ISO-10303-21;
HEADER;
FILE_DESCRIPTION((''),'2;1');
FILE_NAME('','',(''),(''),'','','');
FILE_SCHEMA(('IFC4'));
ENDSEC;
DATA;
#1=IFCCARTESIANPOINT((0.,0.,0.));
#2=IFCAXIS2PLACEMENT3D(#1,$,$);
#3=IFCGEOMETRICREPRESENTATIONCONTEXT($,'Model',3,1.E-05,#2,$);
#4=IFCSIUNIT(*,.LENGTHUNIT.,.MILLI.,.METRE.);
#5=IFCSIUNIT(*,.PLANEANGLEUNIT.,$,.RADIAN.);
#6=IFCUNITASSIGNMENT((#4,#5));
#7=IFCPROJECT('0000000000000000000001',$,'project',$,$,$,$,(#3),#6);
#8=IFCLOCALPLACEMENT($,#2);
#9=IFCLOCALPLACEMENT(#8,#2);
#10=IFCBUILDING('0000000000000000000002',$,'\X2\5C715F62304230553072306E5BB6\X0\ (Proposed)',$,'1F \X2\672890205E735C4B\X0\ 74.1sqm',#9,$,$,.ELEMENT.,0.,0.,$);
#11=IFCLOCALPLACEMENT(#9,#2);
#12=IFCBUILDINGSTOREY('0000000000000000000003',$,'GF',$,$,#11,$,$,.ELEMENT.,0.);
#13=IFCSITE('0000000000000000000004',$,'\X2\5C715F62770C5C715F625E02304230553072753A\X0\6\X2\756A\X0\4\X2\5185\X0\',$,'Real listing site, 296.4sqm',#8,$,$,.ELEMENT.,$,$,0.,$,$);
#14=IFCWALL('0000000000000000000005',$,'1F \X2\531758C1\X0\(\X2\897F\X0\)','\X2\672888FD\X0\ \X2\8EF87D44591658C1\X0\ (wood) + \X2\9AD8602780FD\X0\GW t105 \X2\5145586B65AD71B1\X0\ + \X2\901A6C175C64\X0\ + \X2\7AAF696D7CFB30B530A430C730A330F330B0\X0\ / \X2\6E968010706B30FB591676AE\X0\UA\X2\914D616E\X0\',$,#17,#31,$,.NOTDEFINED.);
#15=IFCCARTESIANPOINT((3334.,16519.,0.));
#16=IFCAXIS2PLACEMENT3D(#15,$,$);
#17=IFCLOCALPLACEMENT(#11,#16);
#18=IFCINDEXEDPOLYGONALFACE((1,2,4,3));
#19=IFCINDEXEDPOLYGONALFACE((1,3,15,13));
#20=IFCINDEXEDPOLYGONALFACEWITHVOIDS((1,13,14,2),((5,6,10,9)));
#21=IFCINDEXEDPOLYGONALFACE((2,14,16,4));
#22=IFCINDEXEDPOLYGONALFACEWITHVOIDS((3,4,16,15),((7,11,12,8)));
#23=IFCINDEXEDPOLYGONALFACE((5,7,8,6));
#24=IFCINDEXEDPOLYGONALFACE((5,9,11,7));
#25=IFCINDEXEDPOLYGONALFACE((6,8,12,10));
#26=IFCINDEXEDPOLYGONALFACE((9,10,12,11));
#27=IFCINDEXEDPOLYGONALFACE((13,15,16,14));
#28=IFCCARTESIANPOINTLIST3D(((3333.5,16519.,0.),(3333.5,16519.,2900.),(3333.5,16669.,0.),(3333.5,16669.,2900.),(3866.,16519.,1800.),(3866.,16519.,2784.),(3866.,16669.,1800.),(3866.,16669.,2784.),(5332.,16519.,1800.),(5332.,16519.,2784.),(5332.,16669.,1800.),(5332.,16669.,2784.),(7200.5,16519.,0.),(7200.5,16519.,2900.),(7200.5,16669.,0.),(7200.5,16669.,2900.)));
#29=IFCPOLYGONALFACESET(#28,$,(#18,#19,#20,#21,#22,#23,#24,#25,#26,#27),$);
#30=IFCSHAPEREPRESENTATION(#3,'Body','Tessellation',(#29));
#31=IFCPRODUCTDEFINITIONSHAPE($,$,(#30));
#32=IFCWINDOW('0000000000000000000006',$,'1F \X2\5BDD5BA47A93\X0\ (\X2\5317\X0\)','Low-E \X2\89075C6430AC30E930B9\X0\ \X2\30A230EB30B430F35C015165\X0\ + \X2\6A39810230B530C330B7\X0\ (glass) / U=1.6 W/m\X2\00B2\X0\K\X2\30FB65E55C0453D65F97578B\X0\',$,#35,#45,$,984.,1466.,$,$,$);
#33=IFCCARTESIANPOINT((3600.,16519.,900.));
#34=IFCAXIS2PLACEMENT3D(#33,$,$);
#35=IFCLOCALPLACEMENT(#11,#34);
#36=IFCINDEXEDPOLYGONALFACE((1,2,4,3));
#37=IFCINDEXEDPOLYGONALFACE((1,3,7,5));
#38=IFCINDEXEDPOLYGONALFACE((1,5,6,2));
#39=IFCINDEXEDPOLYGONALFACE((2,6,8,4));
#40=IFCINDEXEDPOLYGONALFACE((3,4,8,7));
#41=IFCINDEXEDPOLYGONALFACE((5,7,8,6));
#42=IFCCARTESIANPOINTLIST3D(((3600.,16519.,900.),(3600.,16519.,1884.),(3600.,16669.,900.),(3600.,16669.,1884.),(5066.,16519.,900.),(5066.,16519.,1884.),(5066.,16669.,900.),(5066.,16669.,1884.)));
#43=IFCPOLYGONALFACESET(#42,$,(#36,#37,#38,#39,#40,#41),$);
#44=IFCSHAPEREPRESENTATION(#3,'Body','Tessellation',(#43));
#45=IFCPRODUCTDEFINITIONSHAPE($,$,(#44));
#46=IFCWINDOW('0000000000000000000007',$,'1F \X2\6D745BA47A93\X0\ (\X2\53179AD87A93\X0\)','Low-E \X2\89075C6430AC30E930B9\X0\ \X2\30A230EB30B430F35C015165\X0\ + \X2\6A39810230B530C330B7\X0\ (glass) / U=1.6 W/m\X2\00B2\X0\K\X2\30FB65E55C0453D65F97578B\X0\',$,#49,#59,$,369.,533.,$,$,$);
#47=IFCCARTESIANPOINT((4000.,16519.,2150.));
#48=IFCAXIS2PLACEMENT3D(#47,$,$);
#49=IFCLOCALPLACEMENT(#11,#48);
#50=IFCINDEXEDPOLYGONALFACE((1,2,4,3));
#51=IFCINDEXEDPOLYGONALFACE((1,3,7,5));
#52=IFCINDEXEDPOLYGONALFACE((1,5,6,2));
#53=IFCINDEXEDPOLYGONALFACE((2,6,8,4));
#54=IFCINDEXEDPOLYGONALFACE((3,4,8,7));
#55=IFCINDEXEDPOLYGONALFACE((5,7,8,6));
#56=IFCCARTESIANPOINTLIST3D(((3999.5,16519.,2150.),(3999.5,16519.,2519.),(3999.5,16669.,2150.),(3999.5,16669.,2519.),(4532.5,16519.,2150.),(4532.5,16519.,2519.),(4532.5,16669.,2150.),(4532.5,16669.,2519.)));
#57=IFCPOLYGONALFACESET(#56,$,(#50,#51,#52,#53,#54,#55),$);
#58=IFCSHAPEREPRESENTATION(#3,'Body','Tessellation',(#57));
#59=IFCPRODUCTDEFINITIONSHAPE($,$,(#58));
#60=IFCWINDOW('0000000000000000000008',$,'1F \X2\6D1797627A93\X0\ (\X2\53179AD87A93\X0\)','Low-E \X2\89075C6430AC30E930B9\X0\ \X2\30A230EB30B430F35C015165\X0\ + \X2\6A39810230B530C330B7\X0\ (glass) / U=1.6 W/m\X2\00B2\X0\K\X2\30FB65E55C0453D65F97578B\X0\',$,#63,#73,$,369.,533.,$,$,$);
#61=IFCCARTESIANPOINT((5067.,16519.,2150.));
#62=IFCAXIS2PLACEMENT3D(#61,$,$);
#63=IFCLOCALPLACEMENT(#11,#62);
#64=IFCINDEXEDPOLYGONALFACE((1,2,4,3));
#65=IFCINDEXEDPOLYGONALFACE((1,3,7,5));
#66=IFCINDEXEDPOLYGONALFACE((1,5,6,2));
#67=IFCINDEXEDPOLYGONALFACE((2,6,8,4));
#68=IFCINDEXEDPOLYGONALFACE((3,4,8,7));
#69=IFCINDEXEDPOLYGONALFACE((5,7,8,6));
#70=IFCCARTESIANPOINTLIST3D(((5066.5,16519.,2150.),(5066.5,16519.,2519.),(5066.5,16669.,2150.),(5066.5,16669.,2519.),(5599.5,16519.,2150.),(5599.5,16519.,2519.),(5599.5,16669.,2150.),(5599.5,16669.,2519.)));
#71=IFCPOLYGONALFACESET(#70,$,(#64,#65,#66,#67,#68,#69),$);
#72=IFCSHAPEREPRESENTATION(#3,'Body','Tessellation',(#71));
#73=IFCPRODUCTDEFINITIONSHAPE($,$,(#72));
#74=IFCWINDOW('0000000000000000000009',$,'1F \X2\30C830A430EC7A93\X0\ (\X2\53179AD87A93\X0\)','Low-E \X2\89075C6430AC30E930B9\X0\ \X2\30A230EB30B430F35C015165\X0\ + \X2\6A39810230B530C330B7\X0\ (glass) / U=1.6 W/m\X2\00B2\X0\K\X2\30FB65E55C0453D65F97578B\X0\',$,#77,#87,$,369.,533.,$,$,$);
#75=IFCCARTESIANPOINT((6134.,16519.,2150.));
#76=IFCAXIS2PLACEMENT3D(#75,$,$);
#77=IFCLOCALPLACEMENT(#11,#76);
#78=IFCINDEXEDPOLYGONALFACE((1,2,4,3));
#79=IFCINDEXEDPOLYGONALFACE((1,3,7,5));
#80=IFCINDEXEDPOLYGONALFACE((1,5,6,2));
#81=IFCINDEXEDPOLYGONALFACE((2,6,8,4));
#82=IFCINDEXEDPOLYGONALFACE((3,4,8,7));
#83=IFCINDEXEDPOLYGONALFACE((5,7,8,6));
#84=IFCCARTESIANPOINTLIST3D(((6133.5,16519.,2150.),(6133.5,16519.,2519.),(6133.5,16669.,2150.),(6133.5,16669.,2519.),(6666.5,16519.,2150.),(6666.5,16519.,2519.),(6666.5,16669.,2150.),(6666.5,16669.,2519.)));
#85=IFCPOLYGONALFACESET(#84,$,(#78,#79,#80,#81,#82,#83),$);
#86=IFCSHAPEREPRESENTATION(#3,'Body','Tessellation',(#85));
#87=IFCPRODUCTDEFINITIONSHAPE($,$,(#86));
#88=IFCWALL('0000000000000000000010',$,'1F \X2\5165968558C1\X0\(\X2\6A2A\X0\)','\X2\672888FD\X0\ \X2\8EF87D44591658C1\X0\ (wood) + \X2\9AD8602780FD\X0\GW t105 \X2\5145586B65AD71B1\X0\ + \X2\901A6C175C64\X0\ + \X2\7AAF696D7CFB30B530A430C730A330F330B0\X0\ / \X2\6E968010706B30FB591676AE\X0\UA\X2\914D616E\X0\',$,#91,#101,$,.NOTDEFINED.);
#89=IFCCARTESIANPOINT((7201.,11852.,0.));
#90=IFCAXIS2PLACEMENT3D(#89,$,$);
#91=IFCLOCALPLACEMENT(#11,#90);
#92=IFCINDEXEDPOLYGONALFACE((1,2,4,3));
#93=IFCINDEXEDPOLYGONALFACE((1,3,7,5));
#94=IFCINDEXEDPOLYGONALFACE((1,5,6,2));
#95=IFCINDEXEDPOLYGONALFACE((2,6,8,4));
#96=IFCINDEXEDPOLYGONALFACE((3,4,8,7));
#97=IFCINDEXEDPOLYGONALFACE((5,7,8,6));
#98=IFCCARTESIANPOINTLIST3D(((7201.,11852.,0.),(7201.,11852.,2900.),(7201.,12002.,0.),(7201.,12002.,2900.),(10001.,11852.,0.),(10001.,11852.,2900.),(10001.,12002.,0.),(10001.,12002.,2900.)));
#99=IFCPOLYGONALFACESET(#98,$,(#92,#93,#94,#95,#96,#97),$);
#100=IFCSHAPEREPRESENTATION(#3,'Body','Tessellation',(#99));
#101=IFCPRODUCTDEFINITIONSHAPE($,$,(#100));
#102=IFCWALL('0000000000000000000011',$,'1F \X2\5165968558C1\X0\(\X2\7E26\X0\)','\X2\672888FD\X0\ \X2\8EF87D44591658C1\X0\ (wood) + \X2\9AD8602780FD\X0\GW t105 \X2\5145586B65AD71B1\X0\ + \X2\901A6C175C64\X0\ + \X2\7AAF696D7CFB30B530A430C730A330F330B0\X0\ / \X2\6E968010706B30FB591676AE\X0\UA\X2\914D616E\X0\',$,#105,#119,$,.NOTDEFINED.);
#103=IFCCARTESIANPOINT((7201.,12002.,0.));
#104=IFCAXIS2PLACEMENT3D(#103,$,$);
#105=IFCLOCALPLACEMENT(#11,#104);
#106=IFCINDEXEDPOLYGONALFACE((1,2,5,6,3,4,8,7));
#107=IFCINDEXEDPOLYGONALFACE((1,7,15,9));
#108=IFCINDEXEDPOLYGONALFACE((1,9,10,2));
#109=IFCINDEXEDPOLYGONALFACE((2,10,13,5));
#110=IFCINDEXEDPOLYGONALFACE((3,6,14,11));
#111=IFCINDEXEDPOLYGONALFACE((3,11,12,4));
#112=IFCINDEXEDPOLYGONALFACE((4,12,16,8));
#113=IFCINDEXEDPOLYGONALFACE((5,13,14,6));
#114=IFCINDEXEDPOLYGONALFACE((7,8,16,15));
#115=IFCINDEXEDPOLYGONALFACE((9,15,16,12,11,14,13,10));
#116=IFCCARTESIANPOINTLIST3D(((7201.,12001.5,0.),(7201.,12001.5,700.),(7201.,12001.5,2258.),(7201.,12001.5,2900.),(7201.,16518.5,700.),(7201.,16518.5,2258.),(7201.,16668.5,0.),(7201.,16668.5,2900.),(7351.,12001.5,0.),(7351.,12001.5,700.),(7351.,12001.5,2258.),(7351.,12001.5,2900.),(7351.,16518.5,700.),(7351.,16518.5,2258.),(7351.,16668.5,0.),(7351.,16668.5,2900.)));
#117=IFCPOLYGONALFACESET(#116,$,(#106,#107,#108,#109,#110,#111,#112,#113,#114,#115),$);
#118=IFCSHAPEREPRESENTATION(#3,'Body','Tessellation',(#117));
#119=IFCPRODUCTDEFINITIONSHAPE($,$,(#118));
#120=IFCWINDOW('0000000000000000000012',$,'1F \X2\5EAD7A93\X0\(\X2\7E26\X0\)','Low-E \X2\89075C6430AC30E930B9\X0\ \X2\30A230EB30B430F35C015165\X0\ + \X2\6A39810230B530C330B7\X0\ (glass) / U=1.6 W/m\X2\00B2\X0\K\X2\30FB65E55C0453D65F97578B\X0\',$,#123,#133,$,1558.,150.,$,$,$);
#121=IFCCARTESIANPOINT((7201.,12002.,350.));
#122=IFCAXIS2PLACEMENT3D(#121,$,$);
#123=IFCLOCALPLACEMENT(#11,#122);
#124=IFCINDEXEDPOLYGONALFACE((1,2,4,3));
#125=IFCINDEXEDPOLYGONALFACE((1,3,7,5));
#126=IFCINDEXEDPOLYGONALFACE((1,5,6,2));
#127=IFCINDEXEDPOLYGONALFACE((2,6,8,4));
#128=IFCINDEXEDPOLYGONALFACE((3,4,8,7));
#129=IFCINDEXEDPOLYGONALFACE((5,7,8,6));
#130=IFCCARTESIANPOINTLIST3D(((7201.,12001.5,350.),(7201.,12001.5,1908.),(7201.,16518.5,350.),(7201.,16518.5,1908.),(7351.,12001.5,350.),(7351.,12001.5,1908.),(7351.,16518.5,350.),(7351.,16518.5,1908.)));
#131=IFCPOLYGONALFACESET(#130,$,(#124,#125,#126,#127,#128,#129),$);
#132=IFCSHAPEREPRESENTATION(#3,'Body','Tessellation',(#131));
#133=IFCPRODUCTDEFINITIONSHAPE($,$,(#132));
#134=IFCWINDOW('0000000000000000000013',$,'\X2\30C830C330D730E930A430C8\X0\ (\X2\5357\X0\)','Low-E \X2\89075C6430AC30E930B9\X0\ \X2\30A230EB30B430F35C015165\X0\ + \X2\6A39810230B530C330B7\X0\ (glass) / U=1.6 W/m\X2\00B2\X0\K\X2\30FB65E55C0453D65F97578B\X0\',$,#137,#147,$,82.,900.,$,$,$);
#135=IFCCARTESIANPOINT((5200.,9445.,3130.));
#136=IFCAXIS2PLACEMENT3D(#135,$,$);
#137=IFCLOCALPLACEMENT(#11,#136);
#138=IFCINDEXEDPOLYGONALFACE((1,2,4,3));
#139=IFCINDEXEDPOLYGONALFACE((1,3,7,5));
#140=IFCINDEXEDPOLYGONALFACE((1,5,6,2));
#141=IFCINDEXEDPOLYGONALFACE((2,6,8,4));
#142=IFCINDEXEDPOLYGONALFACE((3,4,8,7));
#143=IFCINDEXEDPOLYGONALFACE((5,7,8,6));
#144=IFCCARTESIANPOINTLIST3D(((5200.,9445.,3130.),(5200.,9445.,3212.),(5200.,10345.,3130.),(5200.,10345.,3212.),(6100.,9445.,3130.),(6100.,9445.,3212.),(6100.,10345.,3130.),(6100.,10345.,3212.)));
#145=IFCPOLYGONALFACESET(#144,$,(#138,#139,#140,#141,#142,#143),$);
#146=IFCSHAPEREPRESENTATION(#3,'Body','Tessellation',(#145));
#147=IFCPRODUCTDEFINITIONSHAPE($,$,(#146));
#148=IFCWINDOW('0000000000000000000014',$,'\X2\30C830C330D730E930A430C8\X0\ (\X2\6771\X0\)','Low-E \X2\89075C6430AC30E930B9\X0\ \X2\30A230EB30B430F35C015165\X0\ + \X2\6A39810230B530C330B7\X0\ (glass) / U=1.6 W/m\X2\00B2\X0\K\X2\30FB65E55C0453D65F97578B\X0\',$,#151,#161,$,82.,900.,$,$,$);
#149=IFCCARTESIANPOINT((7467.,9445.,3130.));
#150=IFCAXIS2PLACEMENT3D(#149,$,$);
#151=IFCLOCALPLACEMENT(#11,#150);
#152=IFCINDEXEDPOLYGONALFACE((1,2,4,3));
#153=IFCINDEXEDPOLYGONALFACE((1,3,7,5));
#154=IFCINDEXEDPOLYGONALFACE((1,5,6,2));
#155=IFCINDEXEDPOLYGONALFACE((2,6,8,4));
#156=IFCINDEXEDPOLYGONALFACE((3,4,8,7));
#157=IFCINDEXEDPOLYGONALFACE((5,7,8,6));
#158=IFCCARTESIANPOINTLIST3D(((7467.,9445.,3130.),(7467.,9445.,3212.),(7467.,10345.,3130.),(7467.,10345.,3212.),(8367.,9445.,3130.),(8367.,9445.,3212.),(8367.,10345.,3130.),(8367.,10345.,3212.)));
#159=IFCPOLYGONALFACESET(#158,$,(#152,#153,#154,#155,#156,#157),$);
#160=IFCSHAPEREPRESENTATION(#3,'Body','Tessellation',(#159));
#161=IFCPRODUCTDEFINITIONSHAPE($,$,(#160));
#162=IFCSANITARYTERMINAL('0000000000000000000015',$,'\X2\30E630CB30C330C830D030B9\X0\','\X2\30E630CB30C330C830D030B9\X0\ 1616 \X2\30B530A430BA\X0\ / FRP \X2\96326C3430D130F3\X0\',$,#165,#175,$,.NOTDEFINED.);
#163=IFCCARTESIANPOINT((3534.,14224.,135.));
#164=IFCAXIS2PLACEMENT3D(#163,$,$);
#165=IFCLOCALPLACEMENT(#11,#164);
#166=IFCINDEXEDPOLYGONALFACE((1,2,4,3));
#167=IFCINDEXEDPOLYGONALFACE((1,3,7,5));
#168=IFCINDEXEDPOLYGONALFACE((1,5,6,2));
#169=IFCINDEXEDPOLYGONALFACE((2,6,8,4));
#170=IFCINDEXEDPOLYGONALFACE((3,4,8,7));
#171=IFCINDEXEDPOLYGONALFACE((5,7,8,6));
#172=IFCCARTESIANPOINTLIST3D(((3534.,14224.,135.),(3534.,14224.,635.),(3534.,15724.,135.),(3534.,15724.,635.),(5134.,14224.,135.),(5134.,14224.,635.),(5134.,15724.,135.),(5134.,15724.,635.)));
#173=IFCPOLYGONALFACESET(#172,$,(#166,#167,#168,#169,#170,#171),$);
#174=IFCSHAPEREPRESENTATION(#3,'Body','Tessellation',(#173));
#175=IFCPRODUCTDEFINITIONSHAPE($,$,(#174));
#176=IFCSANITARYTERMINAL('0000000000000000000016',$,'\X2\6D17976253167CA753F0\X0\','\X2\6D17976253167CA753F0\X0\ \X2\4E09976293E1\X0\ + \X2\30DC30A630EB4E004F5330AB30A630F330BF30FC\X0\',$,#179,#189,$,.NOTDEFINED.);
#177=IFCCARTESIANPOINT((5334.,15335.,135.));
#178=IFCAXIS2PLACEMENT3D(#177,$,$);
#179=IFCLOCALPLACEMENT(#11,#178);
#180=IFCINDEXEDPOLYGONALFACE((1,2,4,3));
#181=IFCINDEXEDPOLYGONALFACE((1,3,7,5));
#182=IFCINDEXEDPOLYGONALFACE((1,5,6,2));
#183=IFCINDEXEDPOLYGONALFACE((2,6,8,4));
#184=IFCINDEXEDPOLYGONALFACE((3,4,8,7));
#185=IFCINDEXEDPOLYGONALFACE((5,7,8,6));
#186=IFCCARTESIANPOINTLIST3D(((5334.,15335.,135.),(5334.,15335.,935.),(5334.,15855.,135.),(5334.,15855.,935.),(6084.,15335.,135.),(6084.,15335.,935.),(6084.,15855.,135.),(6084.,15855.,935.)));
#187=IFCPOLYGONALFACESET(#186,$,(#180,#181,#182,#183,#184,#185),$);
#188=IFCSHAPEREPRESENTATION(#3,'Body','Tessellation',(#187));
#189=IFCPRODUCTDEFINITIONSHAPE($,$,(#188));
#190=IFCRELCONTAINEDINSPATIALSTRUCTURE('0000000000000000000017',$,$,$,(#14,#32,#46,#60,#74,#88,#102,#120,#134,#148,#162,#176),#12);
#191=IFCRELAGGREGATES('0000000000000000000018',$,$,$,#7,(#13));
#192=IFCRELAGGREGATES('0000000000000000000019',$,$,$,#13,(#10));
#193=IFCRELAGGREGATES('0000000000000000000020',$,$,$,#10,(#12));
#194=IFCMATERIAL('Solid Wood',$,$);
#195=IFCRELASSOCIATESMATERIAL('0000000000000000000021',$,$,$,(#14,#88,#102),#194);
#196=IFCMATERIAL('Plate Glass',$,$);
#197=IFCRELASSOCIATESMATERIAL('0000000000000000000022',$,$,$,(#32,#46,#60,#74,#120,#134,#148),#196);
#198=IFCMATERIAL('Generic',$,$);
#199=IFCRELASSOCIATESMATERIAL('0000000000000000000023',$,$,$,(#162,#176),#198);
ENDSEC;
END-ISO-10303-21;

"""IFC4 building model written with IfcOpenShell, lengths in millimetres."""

from ifc_helpers import new_model, si_unit, frame, frame_2d, origin, place, context, project, spatial, rectangle, extrude, material, element, fill, save


model = new_model("IFC4")

# Units and contexts
model_context = context("Model", 3, precision=1e-05, world=origin())
ifc_project = project(units=[si_unit("LENGTHUNIT", "METRE", prefix="MILLI"), si_unit("PLANEANGLEUNIT", "RADIAN")], contexts=[model_context])

# Site, building, storey
site_placement = place(None, origin())
site = spatial("IfcSite", under=ifc_project, at=site_placement, Name="山形県山形市あさひ町6番4内", ObjectType="Real listing site, 296.4sqm", CompositionType="ELEMENT", RefElevation=0.0)
building_placement = place(site_placement, origin())
building = spatial("IfcBuilding", under=site, at=building_placement, Name="山形あさひの家 (Proposed)", ObjectType="1F 木造平屋 74.1sqm", CompositionType="ELEMENT", ElevationOfRefHeight=0.0, ElevationOfTerrain=0.0)
storey_placement = place(building_placement, origin())
storey = spatial("IfcBuildingStorey", under=building, at=storey_placement, Name="GF", CompositionType="ELEMENT", Elevation=0.0)

# Shared definitions
ifc_material_1 = material(Name="Solid Wood")

# Wall, openings, windows
wall_1_placement = place(storey_placement, frame((3334.0, 16519.0, 0.0)))
wall_1 = element("IfcWall", 1, at=wall_1_placement, inside=storey, material=ifc_material_1, Name="1F 北壁(西)", Description="木製 軸組外壁 (wood) + 高性能GW t105 充填断熱 + 通気層 + 窯業系サイディング / 準耐火・外皮UA配慮", PredefinedType="NOTDEFINED", context=model_context, shape_type="SweptSolid", body=[
    extrude(rectangle(XDim=3867.0, YDim=150.0, at=frame_2d((1933.0, 75.0))), frame((3334.0, 16519.0, 0.0)), (0.0, 0.0, 1.0), 2900.0),
])
opening_1_placement = place(storey_placement, frame((3600.0, 16519.0, 900.0)))
opening_1 = element("IfcOpeningElement", 2, at=opening_1_placement, cuts=wall_1, PredefinedType="NOTDEFINED", context=model_context, shape_type="SweptSolid", body=[
    extrude(rectangle(XDim=1466.0, YDim=150.0, at=frame_2d((733.0, 75.0))), frame((3600.0, 16519.0, 900.0)), (0.0, 0.0, 1.0), 984.0),
])
opening_2_placement = place(storey_placement, frame((4000.0, 16519.0, 2150.0)))
opening_2 = element("IfcOpeningElement", 3, at=opening_2_placement, cuts=wall_1, PredefinedType="NOTDEFINED", context=model_context, shape_type="SweptSolid", body=[
    extrude(rectangle(XDim=533.0, YDim=150.0, at=frame_2d((266.0, 75.0))), frame((4000.0, 16519.0, 2150.0)), (0.0, 0.0, 1.0), 369.0),
])
opening_3_placement = place(storey_placement, frame((5067.0, 16519.0, 2150.0)))
opening_3 = element("IfcOpeningElement", 4, at=opening_3_placement, cuts=wall_1, PredefinedType="NOTDEFINED", context=model_context, shape_type="SweptSolid", body=[
    extrude(rectangle(XDim=533.0, YDim=150.0, at=frame_2d((266.0, 75.0))), frame((5067.0, 16519.0, 2150.0)), (0.0, 0.0, 1.0), 369.0),
])
opening_4_placement = place(storey_placement, frame((6134.0, 16519.0, 2150.0)))
opening_4 = element("IfcOpeningElement", 5, at=opening_4_placement, cuts=wall_1, PredefinedType="NOTDEFINED", context=model_context, shape_type="SweptSolid", body=[
    extrude(rectangle(XDim=533.0, YDim=150.0, at=frame_2d((266.0, 75.0))), frame((6134.0, 16519.0, 2150.0)), (0.0, 0.0, 1.0), 369.0),
])
ifc_material_2 = material(Name="Plate Glass")
window_1_placement = place(storey_placement, frame((3600.0, 16519.0, 900.0)))
window_1 = element("IfcWindow", 6, at=window_1_placement, inside=storey, material=ifc_material_2, Name="1F 寝室窓 (北)", Description="Low-E 複層ガラス アルゴン封入 + 樹脂サッシ (glass) / U=1.6 W/m²K・日射取得型", OverallHeight=984.0, OverallWidth=1466.0, context=model_context, shape_type="SweptSolid", body=[
    extrude(rectangle(XDim=1466.0, YDim=150.0, at=frame_2d((733.0, 75.0))), frame((3600.0, 16519.0, 900.0)), (0.0, 0.0, 1.0), 984.0),
])
fill(opening_1, window_1)
window_2_placement = place(storey_placement, frame((4000.0, 16519.0, 2150.0)))
window_2 = element("IfcWindow", 7, at=window_2_placement, inside=storey, material=ifc_material_2, Name="1F 浴室窓 (北高窓)", Description="Low-E 複層ガラス アルゴン封入 + 樹脂サッシ (glass) / U=1.6 W/m²K・日射取得型", OverallHeight=369.0, OverallWidth=533.0, context=model_context, shape_type="SweptSolid", body=[
    extrude(rectangle(XDim=533.0, YDim=150.0, at=frame_2d((266.0, 75.0))), frame((4000.0, 16519.0, 2150.0)), (0.0, 0.0, 1.0), 369.0),
])
fill(opening_2, window_2)
window_3_placement = place(storey_placement, frame((5067.0, 16519.0, 2150.0)))
window_3 = element("IfcWindow", 8, at=window_3_placement, inside=storey, material=ifc_material_2, Name="1F 洗面窓 (北高窓)", Description="Low-E 複層ガラス アルゴン封入 + 樹脂サッシ (glass) / U=1.6 W/m²K・日射取得型", OverallHeight=369.0, OverallWidth=533.0, context=model_context, shape_type="SweptSolid", body=[
    extrude(rectangle(XDim=533.0, YDim=150.0, at=frame_2d((266.0, 75.0))), frame((5067.0, 16519.0, 2150.0)), (0.0, 0.0, 1.0), 369.0),
])
fill(opening_3, window_3)
window_4_placement = place(storey_placement, frame((6134.0, 16519.0, 2150.0)))
window_4 = element("IfcWindow", 9, at=window_4_placement, inside=storey, material=ifc_material_2, Name="1F トイレ窓 (北高窓)", Description="Low-E 複層ガラス アルゴン封入 + 樹脂サッシ (glass) / U=1.6 W/m²K・日射取得型", OverallHeight=369.0, OverallWidth=533.0, context=model_context, shape_type="SweptSolid", body=[
    extrude(rectangle(XDim=533.0, YDim=150.0, at=frame_2d((266.0, 75.0))), frame((6134.0, 16519.0, 2150.0)), (0.0, 0.0, 1.0), 369.0),
])
fill(opening_4, window_4)

# Wall
wall_2_placement = place(storey_placement, frame((7201.0, 11852.0, 0.0)))
element("IfcWall", 10, at=wall_2_placement, inside=storey, material=ifc_material_1, Name="1F 入隅壁(横)", Description="木製 軸組外壁 (wood) + 高性能GW t105 充填断熱 + 通気層 + 窯業系サイディング / 準耐火・外皮UA配慮", PredefinedType="NOTDEFINED", context=model_context, shape_type="SweptSolid", body=[
    extrude(rectangle(XDim=2800.0, YDim=150.0, at=frame_2d((1400.0, 75.0))), frame((7201.0, 11852.0, 0.0)), (0.0, 0.0, 1.0), 2900.0),
])

# Wall, opening, window
wall_3_placement = place(storey_placement, frame((7201.0, 12002.0, 0.0)))
wall_3 = element("IfcWall", 11, at=wall_3_placement, inside=storey, material=ifc_material_1, Name="1F 入隅壁(縦)", Description="木製 軸組外壁 (wood) + 高性能GW t105 充填断熱 + 通気層 + 窯業系サイディング / 準耐火・外皮UA配慮", PredefinedType="NOTDEFINED", context=model_context, shape_type="SweptSolid", body=[
    extrude(rectangle(XDim=150.0, YDim=4667.0, at=frame_2d((75.0, 2333.0))), frame((7201.0, 12002.0, 0.0)), (0.0, 0.0, 1.0), 2900.0),
])
opening_5_placement = place(storey_placement, frame((7201.0, 12002.0, 350.0)))
opening_5 = element("IfcOpeningElement", 12, at=opening_5_placement, cuts=wall_3, PredefinedType="NOTDEFINED", context=model_context, shape_type="SweptSolid", body=[
    extrude(rectangle(XDim=150.0, YDim=4517.0, at=frame_2d((75.0, 2258.0))), frame((7201.0, 12002.0, 350.0)), (0.0, 0.0, 1.0), 1558.0),
])
window_5_placement = place(storey_placement, frame((7201.0, 12002.0, 350.0)))
window_5 = element("IfcWindow", 13, at=window_5_placement, inside=storey, material=ifc_material_2, Name="1F 庭窓(縦)", Description="Low-E 複層ガラス アルゴン封入 + 樹脂サッシ (glass) / U=1.6 W/m²K・日射取得型", OverallHeight=1558.0, OverallWidth=150.0, context=model_context, shape_type="SweptSolid", body=[
    extrude(rectangle(XDim=150.0, YDim=4517.0, at=frame_2d((75.0, 2258.0))), frame((7201.0, 12002.0, 350.0)), (0.0, 0.0, 1.0), 1558.0),
])
fill(opening_5, window_5)

# Windows
window_6_placement = place(storey_placement, frame((5200.0, 9445.0, 3130.0)))
element("IfcWindow", 14, at=window_6_placement, inside=storey, material=ifc_material_2, Name="トップライト (南)", Description="Low-E 複層ガラス アルゴン封入 + 樹脂サッシ (glass) / U=1.6 W/m²K・日射取得型", OverallHeight=82.0, OverallWidth=900.0, context=model_context, shape_type="SweptSolid", body=[
    extrude(rectangle(XDim=900.0, YDim=900.0, at=frame_2d((450.0, 450.0))), frame((5200.0, 9445.0, 3130.0)), (0.0, 0.0, 1.0), 82.0),
])
window_7_placement = place(storey_placement, frame((7467.0, 9445.0, 3130.0)))
element("IfcWindow", 15, at=window_7_placement, inside=storey, material=ifc_material_2, Name="トップライト (東)", Description="Low-E 複層ガラス アルゴン封入 + 樹脂サッシ (glass) / U=1.6 W/m²K・日射取得型", OverallHeight=82.0, OverallWidth=900.0, context=model_context, shape_type="SweptSolid", body=[
    extrude(rectangle(XDim=900.0, YDim=900.0, at=frame_2d((450.0, 450.0))), frame((7467.0, 9445.0, 3130.0)), (0.0, 0.0, 1.0), 82.0),
])

# Shared definitions
ifc_material_3 = material(Name="Generic")

# Sanitary terminals
sanitary_terminal_1_placement = place(storey_placement, frame((3534.0, 14224.0, 135.0)))
element("IfcSanitaryTerminal", 16, at=sanitary_terminal_1_placement, inside=storey, material=ifc_material_3, Name="ユニットバス", Description="ユニットバス 1616 サイズ / FRP 防水パン", PredefinedType="NOTDEFINED", context=model_context, shape_type="SweptSolid", body=[
    extrude(rectangle(XDim=1600.0, YDim=1500.0, at=frame_2d((800.0, 750.0))), frame((3534.0, 14224.0, 135.0)), (0.0, 0.0, 1.0), 500.0),
])
sanitary_terminal_2_placement = place(storey_placement, frame((5334.0, 15335.0, 135.0)))
element("IfcSanitaryTerminal", 17, at=sanitary_terminal_2_placement, inside=storey, material=ifc_material_3, Name="洗面化粧台", Description="洗面化粧台 三面鏡 + ボウル一体カウンター", PredefinedType="NOTDEFINED", context=model_context, shape_type="SweptSolid", body=[
    extrude(rectangle(XDim=750.0, YDim=520.0, at=frame_2d((375.0, 260.0))), frame((5334.0, 15335.0, 135.0)), (0.0, 0.0, 1.0), 800.0),
])

save(model, "model.ifc")
